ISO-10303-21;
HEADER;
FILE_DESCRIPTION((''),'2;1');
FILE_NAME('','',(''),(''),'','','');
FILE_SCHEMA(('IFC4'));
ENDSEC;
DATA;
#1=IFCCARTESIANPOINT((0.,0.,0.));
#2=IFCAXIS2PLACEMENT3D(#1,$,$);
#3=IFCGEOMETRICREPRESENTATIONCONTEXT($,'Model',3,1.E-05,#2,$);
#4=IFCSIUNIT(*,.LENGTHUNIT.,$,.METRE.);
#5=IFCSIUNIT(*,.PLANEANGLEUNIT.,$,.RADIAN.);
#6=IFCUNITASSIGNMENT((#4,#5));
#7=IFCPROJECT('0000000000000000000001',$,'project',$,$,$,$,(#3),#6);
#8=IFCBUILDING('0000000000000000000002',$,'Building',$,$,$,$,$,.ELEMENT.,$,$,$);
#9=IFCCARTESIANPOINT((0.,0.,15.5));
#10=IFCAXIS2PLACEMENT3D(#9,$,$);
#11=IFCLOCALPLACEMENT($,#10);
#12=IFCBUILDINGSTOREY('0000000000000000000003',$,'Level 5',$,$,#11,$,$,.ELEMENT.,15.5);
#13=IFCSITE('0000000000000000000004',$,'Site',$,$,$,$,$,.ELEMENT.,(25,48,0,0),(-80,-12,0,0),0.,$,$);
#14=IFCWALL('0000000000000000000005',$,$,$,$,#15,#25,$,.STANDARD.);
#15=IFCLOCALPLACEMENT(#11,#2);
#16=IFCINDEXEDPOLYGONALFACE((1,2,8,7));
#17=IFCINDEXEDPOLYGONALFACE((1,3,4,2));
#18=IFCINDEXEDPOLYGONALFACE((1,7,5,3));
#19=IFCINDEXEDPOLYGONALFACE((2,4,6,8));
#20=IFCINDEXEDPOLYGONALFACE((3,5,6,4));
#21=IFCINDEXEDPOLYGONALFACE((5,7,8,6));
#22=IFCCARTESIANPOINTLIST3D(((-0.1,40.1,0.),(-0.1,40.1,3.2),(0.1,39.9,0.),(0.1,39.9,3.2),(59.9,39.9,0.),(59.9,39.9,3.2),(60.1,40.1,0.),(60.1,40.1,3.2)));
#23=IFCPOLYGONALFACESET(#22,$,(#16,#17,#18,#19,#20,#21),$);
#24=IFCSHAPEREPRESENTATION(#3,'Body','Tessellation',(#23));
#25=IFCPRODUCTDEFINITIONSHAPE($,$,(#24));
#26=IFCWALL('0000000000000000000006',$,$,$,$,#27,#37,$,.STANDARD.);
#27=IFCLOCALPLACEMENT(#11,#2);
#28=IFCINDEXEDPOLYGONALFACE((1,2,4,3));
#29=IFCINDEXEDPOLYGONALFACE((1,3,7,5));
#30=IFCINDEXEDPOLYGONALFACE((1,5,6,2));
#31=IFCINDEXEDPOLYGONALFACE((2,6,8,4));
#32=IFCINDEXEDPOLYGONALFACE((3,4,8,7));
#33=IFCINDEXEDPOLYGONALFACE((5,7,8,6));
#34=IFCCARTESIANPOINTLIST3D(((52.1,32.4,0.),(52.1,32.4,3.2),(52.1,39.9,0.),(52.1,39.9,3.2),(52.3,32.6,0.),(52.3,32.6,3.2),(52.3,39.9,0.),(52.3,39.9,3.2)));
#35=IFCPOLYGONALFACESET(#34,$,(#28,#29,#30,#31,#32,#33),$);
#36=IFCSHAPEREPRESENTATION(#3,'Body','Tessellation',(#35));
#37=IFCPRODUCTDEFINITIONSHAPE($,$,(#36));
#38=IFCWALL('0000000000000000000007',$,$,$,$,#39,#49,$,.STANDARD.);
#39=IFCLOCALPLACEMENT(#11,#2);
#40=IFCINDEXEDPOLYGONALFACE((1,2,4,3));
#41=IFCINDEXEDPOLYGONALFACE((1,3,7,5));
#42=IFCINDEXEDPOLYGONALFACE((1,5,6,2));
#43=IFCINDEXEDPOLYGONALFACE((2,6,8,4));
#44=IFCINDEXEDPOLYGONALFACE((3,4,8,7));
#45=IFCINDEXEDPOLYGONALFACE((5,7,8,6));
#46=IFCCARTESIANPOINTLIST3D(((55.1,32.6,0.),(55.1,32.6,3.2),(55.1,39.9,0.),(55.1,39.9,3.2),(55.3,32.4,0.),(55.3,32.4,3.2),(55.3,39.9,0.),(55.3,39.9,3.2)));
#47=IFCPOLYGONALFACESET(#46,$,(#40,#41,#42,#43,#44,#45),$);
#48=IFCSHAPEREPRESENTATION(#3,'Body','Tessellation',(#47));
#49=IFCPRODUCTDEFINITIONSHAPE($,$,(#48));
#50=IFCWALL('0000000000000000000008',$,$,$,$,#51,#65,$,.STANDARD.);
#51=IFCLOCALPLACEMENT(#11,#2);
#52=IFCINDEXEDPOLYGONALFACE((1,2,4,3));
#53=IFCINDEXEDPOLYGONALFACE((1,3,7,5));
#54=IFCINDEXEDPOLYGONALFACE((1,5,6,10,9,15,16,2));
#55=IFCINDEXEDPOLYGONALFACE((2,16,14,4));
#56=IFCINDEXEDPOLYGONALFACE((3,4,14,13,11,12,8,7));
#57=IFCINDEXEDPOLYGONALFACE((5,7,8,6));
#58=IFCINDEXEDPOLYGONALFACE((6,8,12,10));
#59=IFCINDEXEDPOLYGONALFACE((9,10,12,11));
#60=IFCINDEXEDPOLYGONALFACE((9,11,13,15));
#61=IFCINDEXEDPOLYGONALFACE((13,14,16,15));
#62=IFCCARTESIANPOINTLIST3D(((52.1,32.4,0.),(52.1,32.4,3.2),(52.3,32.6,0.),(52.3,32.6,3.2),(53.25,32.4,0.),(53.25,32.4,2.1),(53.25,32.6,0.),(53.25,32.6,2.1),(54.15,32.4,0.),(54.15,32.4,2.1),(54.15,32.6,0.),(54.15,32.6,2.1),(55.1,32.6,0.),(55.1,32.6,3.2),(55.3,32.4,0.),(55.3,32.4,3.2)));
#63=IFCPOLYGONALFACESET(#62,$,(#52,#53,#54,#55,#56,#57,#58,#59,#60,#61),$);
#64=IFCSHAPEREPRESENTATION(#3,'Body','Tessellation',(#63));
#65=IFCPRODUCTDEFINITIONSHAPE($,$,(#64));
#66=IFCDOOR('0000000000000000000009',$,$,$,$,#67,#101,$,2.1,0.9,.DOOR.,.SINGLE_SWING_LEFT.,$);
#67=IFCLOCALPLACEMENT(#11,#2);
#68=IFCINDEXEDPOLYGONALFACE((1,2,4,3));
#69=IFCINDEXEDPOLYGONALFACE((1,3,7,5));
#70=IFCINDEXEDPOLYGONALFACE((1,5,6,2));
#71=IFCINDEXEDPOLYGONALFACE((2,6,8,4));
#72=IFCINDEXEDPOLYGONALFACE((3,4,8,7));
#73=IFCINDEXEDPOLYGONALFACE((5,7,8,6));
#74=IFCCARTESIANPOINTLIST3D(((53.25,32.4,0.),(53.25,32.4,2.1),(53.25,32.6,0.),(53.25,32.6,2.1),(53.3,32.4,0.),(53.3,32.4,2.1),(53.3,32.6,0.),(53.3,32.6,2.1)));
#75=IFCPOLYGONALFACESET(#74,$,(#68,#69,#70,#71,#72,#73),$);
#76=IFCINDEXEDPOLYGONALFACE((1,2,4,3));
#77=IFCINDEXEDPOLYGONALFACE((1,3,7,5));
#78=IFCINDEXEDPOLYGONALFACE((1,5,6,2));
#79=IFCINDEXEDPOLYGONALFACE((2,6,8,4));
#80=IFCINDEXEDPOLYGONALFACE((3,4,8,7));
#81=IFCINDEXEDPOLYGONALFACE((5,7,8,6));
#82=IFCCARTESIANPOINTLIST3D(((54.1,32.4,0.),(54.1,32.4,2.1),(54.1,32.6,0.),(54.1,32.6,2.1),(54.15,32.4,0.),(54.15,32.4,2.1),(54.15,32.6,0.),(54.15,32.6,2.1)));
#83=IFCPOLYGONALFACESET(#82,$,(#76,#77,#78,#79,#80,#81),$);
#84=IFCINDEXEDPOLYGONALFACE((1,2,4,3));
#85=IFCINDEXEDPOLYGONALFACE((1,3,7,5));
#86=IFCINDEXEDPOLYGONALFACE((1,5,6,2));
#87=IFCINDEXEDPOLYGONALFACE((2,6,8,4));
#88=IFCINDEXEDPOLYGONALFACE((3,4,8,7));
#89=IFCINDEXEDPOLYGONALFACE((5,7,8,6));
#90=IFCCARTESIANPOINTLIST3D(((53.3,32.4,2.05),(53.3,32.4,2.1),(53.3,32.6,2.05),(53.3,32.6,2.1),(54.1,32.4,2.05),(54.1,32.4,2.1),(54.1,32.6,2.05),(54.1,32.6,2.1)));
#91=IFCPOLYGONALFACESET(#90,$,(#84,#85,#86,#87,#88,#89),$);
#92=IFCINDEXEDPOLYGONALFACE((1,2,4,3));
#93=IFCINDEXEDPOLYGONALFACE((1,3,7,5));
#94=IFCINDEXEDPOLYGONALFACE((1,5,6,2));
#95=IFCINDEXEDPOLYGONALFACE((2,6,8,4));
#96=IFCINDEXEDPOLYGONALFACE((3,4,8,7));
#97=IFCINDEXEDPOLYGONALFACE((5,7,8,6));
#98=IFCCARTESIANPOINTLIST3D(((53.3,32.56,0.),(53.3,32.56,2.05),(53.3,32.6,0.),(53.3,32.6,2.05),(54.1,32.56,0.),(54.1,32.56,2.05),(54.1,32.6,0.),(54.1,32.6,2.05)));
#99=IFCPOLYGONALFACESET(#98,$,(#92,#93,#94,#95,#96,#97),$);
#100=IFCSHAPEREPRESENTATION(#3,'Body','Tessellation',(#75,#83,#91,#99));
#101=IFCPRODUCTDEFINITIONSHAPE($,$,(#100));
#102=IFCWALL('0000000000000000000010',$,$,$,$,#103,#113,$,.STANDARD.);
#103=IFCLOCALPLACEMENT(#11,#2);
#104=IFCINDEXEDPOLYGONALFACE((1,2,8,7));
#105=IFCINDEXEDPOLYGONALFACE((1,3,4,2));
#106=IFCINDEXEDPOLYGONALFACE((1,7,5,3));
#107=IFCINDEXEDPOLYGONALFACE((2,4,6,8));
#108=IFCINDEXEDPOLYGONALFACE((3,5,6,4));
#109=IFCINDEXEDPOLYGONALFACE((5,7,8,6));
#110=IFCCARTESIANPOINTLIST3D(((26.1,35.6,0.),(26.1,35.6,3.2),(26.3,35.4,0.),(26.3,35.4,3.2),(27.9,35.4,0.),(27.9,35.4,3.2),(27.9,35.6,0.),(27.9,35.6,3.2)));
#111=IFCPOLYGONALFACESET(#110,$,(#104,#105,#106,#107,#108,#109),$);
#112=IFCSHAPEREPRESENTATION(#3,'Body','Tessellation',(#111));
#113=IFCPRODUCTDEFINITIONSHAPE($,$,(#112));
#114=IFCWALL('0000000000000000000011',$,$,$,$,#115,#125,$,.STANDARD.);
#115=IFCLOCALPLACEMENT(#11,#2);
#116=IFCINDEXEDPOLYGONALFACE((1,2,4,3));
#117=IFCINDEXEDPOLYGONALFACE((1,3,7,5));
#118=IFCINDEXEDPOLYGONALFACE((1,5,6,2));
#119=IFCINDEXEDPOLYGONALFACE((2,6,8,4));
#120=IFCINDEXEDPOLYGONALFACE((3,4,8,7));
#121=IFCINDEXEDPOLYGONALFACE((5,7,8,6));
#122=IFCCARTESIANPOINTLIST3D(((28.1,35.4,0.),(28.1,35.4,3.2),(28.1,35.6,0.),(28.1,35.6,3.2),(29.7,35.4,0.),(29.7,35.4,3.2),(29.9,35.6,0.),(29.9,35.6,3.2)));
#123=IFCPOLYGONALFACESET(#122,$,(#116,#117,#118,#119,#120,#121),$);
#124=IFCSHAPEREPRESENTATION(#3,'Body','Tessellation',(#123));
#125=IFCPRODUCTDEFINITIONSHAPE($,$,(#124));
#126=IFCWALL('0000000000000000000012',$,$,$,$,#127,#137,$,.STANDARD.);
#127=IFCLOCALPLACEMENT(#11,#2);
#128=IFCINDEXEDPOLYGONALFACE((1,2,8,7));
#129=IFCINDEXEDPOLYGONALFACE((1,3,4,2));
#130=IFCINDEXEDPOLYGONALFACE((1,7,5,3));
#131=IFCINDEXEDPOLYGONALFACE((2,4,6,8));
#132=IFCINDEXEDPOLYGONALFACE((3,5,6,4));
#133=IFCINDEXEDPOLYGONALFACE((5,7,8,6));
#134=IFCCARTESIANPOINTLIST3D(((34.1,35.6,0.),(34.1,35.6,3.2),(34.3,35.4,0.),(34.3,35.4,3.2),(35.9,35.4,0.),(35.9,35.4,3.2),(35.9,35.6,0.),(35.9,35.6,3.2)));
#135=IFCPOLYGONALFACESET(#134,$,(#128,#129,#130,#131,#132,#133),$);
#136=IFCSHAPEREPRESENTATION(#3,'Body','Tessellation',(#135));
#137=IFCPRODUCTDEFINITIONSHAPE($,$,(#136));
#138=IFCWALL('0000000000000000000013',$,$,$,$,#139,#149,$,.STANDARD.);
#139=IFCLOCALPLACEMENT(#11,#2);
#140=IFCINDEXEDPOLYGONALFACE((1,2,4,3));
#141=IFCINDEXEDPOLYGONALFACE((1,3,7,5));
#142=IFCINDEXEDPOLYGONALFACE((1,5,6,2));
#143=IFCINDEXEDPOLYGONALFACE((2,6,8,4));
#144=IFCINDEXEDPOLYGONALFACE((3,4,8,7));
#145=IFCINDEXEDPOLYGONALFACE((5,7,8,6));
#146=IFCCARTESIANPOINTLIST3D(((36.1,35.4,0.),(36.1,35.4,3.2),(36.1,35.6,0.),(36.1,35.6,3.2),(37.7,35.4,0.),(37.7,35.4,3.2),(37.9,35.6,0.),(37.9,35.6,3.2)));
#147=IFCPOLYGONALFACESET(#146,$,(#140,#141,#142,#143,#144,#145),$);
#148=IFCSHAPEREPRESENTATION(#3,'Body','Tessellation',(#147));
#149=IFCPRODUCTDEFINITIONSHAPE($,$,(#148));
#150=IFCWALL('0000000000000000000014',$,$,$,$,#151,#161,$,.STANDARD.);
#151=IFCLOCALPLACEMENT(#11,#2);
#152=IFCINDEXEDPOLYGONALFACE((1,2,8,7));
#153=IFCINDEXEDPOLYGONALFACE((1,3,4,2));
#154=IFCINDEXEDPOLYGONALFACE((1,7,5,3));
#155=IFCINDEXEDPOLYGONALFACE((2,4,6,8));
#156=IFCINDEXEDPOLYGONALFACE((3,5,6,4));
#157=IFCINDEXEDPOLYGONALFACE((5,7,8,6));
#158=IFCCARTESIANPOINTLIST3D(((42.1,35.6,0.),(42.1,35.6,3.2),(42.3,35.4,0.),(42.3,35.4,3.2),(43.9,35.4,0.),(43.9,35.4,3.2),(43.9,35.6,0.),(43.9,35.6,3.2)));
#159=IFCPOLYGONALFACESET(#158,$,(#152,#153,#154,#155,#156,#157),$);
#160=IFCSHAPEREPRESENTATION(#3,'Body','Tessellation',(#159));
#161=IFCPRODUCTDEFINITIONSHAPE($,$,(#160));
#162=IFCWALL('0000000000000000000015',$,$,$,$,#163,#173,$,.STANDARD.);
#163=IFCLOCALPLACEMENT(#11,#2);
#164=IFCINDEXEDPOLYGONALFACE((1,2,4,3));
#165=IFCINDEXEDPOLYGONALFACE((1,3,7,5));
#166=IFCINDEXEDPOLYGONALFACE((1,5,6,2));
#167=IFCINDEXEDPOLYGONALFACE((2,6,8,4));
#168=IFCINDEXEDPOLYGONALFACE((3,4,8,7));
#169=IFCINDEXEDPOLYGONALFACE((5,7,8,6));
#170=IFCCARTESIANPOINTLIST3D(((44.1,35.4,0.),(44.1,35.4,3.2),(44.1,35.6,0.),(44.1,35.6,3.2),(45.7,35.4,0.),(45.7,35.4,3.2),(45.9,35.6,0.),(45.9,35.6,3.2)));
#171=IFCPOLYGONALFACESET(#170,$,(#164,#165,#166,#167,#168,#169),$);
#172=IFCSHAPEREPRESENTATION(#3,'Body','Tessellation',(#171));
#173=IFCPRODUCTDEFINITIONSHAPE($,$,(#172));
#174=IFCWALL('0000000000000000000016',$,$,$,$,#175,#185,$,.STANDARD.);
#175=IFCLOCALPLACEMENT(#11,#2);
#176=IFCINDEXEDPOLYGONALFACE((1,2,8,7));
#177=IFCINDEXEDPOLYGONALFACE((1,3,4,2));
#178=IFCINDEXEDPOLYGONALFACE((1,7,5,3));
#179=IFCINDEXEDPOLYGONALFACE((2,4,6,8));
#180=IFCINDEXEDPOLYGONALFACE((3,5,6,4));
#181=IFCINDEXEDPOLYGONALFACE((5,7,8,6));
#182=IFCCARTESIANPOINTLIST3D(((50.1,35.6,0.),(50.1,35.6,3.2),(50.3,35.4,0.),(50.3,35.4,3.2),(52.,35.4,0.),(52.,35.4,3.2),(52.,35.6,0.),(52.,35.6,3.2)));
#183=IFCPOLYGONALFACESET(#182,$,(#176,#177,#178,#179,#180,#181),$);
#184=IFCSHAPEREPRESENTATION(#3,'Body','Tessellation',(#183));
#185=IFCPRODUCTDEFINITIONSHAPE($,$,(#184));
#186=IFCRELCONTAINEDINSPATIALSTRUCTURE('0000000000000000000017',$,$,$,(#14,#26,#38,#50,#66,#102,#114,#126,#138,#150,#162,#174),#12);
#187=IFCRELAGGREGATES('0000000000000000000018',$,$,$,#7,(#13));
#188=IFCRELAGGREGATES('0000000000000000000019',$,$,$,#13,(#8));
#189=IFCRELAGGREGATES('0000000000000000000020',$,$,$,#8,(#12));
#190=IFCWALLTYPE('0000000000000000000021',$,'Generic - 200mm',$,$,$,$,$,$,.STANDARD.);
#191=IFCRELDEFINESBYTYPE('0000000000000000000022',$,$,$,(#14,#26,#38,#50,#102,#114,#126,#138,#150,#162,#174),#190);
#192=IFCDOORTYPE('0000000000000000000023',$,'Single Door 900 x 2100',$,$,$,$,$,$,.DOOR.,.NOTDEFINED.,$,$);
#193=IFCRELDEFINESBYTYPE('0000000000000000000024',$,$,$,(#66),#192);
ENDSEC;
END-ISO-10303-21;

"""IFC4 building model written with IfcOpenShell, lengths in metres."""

from ifc_helpers import new_model, si_unit, frame, frame_2d, origin, origin_with_axes, origin_2d, place, context, project, spatial, polyline, rectangle, outline, extrude, type_object, element, fill, save


model = new_model("IFC4")

# Units and contexts
model_context = context("Model", 3, precision=1e-05, world=origin())
ifc_project = project(units=[si_unit("LENGTHUNIT", "METRE"), si_unit("PLANEANGLEUNIT", "RADIAN")], contexts=[model_context])

# Site, building, storey
site = spatial("IfcSite", under=ifc_project, Name="Site", CompositionType="ELEMENT", RefLatitude=(25, 48, 0, 0), RefLongitude=(-80, -12, 0, 0), RefElevation=0.0)
building = spatial("IfcBuilding", under=site, Name="Building", CompositionType="ELEMENT")
storey_placement = place(None, frame((0.0, 0.0, 15.5)))
storey = spatial("IfcBuildingStorey", under=building, at=storey_placement, Name="Level 5", CompositionType="ELEMENT", Elevation=15.5)

# Walls
wall_type = type_object("IfcWallType", Name="Generic - 200mm", PredefinedType="STANDARD")
wall_1_placement = place(None, frame((60.0, 40.0, 15.5), z_axis=(0.0, 0.0, 1.0), x_axis=(-1.0, 0.0, 0.0)))
element("IfcWall", 1, at=wall_1_placement, inside=storey, type_object=wall_type, PredefinedType="STANDARD", context=model_context, shape_type="SweptSolid", body=[
    extrude(outline(polyline([(-0.1, -0.1), (60.1, -0.1), (59.9, 0.1), (0.1, 0.1), (-0.1, -0.1)])), origin(), (0.0, 0.0, 1.0), 3.2),
])
wall_2_placement = place(None, frame((52.2, 32.5, 15.5), z_axis=(0.0, 0.0, 1.0), x_axis=(0.0, 1.0, 0.0)))
element("IfcWall", 2, at=wall_2_placement, inside=storey, type_object=wall_type, PredefinedType="STANDARD", context=model_context, shape_type="SweptSolid", body=[
    extrude(outline(polyline([(0.1, -0.1), (7.4, -0.1), (7.4, 0.1), (-0.1, 0.1), (0.1, -0.1)])), origin(), (0.0, 0.0, 1.0), 3.2),
])
wall_3_placement = place(None, frame((55.2, 32.5, 15.5), z_axis=(0.0, 0.0, 1.0), x_axis=(0.0, 1.0, 0.0)))
element("IfcWall", 3, at=wall_3_placement, inside=storey, type_object=wall_type, PredefinedType="STANDARD", context=model_context, shape_type="SweptSolid", body=[
    extrude(outline(polyline([(-0.1, -0.1), (7.4, -0.1), (7.4, 0.1), (0.1, 0.1), (-0.1, -0.1)])), origin(), (0.0, 0.0, 1.0), 3.2),
])

# Wall, opening, door
wall_4_placement = place(None, frame((52.2, 32.5, 15.5), z_axis=(0.0, 0.0, 1.0), x_axis=(1.0, 0.0, 0.0)))
wall_4 = element("IfcWall", 4, at=wall_4_placement, inside=storey, type_object=wall_type, PredefinedType="STANDARD", context=model_context, shape_type="SweptSolid", body=[
    extrude(outline(polyline([(-0.1, -0.1), (3.1, -0.1), (2.9, 0.1), (0.1, 0.1), (-0.1, -0.1)])), origin(), (0.0, 0.0, 1.0), 3.2),
])
opening_placement = place(wall_4_placement, frame((1.5, 0.0, 0.0), z_axis=(0.0, 0.0, 1.0), x_axis=(1.0, 0.0, 0.0)))
opening = element("IfcOpeningElement", 5, at=opening_placement, cuts=wall_4, PredefinedType="OPENING", context=model_context, shape_type="SweptSolid", body=[
    extrude(rectangle(XDim=0.9, YDim=0.202, at=origin_2d()), origin(), (0.0, 0.0, 1.0), 2.1),
])
door_type = type_object("IfcDoorType", Name="Single Door 900 x 2100", OperationType="NOTDEFINED", PredefinedType="DOOR")
door_placement = place(opening_placement, origin_with_axes())
door = element("IfcDoor", 6, at=door_placement, inside=storey, type_object=door_type, OperationType="SINGLE_SWING_LEFT", OverallHeight=2.1, OverallWidth=0.9, PredefinedType="DOOR", context=model_context, shape_type="SweptSolid", body=[
    extrude(rectangle(XDim=0.05, YDim=0.2, at=frame_2d((-0.425, 0.0))), origin(), (0.0, 0.0, 1.0), 2.1),
    extrude(rectangle(XDim=0.05, YDim=0.2, at=frame_2d((0.425, 0.0))), origin(), (0.0, 0.0, 1.0), 2.1),
    extrude(rectangle(XDim=0.8, YDim=0.2, at=origin_2d()), frame((0.0, 0.0, 2.05)), (0.0, 0.0, 1.0), 0.05),
    extrude(rectangle(XDim=0.8, YDim=0.04, at=frame_2d((0.0, 0.08))), origin(), (0.0, 0.0, 1.0), 2.05),
])
fill(opening, door)

# Walls
wall_5_placement = place(None, frame((26.2, 35.5, 15.5), z_axis=(0.0, 0.0, 1.0), x_axis=(1.0, 0.0, 0.0)))
element("IfcWall", 7, at=wall_5_placement, inside=storey, type_object=wall_type, PredefinedType="STANDARD", context=model_context, shape_type="SweptSolid", body=[
    extrude(outline(polyline([(0.1, -0.1), (1.7, -0.1), (1.7, 0.1), (-0.1, 0.1), (0.1, -0.1)])), origin(), (0.0, 0.0, 1.0), 3.2),
])
wall_6_placement = place(None, frame((29.8, 35.5, 15.5), z_axis=(0.0, 0.0, 1.0), x_axis=(-1.0, 0.0, 0.0)))
element("IfcWall", 8, at=wall_6_placement, inside=storey, type_object=wall_type, PredefinedType="STANDARD", context=model_context, shape_type="SweptSolid", body=[
    extrude(outline(polyline([(-0.1, -0.1), (1.7, -0.1), (1.7, 0.1), (0.1, 0.1), (-0.1, -0.1)])), origin(), (0.0, 0.0, 1.0), 3.2),
])
wall_7_placement = place(None, frame((34.2, 35.5, 15.5), z_axis=(0.0, 0.0, 1.0), x_axis=(1.0, 0.0, 0.0)))
element("IfcWall", 9, at=wall_7_placement, inside=storey, type_object=wall_type, PredefinedType="STANDARD", context=model_context, shape_type="SweptSolid", body=[
    extrude(outline(polyline([(0.1, -0.1), (1.7, -0.1), (1.7, 0.1), (-0.1, 0.1), (0.1, -0.1)])), origin(), (0.0, 0.0, 1.0), 3.2),
])
wall_8_placement = place(None, frame((37.8, 35.5, 15.5), z_axis=(0.0, 0.0, 1.0), x_axis=(-1.0, 0.0, 0.0)))
element("IfcWall", 10, at=wall_8_placement, inside=storey, type_object=wall_type, PredefinedType="STANDARD", context=model_context, shape_type="SweptSolid", body=[
    extrude(outline(polyline([(-0.1, -0.1), (1.7, -0.1), (1.7, 0.1), (0.1, 0.1), (-0.1, -0.1)])), origin(), (0.0, 0.0, 1.0), 3.2),
])
wall_9_placement = place(None, frame((42.2, 35.5, 15.5), z_axis=(0.0, 0.0, 1.0), x_axis=(1.0, 0.0, 0.0)))
element("IfcWall", 11, at=wall_9_placement, inside=storey, type_object=wall_type, PredefinedType="STANDARD", context=model_context, shape_type="SweptSolid", body=[
    extrude(outline(polyline([(0.1, -0.1), (1.7, -0.1), (1.7, 0.1), (-0.1, 0.1), (0.1, -0.1)])), origin(), (0.0, 0.0, 1.0), 3.2),
])
wall_10_placement = place(None, frame((45.8, 35.5, 15.5), z_axis=(0.0, 0.0, 1.0), x_axis=(-1.0, 0.0, 0.0)))
element("IfcWall", 12, at=wall_10_placement, inside=storey, type_object=wall_type, PredefinedType="STANDARD", context=model_context, shape_type="SweptSolid", body=[
    extrude(outline(polyline([(-0.1, -0.1), (1.7, -0.1), (1.7, 0.1), (0.1, 0.1), (-0.1, -0.1)])), origin(), (0.0, 0.0, 1.0), 3.2),
])
wall_11_placement = place(None, frame((50.2, 35.5, 15.5), z_axis=(0.0, 0.0, 1.0), x_axis=(1.0, 0.0, 0.0)))
element("IfcWall", 13, at=wall_11_placement, inside=storey, type_object=wall_type, PredefinedType="STANDARD", context=model_context, shape_type="SweptSolid", body=[
    extrude(outline(polyline([(0.1, -0.1), (1.8, -0.1), (1.8, 0.1), (-0.1, 0.1), (0.1, -0.1)])), origin(), (0.0, 0.0, 1.0), 3.2),
])

save(model, "model.ifc")
